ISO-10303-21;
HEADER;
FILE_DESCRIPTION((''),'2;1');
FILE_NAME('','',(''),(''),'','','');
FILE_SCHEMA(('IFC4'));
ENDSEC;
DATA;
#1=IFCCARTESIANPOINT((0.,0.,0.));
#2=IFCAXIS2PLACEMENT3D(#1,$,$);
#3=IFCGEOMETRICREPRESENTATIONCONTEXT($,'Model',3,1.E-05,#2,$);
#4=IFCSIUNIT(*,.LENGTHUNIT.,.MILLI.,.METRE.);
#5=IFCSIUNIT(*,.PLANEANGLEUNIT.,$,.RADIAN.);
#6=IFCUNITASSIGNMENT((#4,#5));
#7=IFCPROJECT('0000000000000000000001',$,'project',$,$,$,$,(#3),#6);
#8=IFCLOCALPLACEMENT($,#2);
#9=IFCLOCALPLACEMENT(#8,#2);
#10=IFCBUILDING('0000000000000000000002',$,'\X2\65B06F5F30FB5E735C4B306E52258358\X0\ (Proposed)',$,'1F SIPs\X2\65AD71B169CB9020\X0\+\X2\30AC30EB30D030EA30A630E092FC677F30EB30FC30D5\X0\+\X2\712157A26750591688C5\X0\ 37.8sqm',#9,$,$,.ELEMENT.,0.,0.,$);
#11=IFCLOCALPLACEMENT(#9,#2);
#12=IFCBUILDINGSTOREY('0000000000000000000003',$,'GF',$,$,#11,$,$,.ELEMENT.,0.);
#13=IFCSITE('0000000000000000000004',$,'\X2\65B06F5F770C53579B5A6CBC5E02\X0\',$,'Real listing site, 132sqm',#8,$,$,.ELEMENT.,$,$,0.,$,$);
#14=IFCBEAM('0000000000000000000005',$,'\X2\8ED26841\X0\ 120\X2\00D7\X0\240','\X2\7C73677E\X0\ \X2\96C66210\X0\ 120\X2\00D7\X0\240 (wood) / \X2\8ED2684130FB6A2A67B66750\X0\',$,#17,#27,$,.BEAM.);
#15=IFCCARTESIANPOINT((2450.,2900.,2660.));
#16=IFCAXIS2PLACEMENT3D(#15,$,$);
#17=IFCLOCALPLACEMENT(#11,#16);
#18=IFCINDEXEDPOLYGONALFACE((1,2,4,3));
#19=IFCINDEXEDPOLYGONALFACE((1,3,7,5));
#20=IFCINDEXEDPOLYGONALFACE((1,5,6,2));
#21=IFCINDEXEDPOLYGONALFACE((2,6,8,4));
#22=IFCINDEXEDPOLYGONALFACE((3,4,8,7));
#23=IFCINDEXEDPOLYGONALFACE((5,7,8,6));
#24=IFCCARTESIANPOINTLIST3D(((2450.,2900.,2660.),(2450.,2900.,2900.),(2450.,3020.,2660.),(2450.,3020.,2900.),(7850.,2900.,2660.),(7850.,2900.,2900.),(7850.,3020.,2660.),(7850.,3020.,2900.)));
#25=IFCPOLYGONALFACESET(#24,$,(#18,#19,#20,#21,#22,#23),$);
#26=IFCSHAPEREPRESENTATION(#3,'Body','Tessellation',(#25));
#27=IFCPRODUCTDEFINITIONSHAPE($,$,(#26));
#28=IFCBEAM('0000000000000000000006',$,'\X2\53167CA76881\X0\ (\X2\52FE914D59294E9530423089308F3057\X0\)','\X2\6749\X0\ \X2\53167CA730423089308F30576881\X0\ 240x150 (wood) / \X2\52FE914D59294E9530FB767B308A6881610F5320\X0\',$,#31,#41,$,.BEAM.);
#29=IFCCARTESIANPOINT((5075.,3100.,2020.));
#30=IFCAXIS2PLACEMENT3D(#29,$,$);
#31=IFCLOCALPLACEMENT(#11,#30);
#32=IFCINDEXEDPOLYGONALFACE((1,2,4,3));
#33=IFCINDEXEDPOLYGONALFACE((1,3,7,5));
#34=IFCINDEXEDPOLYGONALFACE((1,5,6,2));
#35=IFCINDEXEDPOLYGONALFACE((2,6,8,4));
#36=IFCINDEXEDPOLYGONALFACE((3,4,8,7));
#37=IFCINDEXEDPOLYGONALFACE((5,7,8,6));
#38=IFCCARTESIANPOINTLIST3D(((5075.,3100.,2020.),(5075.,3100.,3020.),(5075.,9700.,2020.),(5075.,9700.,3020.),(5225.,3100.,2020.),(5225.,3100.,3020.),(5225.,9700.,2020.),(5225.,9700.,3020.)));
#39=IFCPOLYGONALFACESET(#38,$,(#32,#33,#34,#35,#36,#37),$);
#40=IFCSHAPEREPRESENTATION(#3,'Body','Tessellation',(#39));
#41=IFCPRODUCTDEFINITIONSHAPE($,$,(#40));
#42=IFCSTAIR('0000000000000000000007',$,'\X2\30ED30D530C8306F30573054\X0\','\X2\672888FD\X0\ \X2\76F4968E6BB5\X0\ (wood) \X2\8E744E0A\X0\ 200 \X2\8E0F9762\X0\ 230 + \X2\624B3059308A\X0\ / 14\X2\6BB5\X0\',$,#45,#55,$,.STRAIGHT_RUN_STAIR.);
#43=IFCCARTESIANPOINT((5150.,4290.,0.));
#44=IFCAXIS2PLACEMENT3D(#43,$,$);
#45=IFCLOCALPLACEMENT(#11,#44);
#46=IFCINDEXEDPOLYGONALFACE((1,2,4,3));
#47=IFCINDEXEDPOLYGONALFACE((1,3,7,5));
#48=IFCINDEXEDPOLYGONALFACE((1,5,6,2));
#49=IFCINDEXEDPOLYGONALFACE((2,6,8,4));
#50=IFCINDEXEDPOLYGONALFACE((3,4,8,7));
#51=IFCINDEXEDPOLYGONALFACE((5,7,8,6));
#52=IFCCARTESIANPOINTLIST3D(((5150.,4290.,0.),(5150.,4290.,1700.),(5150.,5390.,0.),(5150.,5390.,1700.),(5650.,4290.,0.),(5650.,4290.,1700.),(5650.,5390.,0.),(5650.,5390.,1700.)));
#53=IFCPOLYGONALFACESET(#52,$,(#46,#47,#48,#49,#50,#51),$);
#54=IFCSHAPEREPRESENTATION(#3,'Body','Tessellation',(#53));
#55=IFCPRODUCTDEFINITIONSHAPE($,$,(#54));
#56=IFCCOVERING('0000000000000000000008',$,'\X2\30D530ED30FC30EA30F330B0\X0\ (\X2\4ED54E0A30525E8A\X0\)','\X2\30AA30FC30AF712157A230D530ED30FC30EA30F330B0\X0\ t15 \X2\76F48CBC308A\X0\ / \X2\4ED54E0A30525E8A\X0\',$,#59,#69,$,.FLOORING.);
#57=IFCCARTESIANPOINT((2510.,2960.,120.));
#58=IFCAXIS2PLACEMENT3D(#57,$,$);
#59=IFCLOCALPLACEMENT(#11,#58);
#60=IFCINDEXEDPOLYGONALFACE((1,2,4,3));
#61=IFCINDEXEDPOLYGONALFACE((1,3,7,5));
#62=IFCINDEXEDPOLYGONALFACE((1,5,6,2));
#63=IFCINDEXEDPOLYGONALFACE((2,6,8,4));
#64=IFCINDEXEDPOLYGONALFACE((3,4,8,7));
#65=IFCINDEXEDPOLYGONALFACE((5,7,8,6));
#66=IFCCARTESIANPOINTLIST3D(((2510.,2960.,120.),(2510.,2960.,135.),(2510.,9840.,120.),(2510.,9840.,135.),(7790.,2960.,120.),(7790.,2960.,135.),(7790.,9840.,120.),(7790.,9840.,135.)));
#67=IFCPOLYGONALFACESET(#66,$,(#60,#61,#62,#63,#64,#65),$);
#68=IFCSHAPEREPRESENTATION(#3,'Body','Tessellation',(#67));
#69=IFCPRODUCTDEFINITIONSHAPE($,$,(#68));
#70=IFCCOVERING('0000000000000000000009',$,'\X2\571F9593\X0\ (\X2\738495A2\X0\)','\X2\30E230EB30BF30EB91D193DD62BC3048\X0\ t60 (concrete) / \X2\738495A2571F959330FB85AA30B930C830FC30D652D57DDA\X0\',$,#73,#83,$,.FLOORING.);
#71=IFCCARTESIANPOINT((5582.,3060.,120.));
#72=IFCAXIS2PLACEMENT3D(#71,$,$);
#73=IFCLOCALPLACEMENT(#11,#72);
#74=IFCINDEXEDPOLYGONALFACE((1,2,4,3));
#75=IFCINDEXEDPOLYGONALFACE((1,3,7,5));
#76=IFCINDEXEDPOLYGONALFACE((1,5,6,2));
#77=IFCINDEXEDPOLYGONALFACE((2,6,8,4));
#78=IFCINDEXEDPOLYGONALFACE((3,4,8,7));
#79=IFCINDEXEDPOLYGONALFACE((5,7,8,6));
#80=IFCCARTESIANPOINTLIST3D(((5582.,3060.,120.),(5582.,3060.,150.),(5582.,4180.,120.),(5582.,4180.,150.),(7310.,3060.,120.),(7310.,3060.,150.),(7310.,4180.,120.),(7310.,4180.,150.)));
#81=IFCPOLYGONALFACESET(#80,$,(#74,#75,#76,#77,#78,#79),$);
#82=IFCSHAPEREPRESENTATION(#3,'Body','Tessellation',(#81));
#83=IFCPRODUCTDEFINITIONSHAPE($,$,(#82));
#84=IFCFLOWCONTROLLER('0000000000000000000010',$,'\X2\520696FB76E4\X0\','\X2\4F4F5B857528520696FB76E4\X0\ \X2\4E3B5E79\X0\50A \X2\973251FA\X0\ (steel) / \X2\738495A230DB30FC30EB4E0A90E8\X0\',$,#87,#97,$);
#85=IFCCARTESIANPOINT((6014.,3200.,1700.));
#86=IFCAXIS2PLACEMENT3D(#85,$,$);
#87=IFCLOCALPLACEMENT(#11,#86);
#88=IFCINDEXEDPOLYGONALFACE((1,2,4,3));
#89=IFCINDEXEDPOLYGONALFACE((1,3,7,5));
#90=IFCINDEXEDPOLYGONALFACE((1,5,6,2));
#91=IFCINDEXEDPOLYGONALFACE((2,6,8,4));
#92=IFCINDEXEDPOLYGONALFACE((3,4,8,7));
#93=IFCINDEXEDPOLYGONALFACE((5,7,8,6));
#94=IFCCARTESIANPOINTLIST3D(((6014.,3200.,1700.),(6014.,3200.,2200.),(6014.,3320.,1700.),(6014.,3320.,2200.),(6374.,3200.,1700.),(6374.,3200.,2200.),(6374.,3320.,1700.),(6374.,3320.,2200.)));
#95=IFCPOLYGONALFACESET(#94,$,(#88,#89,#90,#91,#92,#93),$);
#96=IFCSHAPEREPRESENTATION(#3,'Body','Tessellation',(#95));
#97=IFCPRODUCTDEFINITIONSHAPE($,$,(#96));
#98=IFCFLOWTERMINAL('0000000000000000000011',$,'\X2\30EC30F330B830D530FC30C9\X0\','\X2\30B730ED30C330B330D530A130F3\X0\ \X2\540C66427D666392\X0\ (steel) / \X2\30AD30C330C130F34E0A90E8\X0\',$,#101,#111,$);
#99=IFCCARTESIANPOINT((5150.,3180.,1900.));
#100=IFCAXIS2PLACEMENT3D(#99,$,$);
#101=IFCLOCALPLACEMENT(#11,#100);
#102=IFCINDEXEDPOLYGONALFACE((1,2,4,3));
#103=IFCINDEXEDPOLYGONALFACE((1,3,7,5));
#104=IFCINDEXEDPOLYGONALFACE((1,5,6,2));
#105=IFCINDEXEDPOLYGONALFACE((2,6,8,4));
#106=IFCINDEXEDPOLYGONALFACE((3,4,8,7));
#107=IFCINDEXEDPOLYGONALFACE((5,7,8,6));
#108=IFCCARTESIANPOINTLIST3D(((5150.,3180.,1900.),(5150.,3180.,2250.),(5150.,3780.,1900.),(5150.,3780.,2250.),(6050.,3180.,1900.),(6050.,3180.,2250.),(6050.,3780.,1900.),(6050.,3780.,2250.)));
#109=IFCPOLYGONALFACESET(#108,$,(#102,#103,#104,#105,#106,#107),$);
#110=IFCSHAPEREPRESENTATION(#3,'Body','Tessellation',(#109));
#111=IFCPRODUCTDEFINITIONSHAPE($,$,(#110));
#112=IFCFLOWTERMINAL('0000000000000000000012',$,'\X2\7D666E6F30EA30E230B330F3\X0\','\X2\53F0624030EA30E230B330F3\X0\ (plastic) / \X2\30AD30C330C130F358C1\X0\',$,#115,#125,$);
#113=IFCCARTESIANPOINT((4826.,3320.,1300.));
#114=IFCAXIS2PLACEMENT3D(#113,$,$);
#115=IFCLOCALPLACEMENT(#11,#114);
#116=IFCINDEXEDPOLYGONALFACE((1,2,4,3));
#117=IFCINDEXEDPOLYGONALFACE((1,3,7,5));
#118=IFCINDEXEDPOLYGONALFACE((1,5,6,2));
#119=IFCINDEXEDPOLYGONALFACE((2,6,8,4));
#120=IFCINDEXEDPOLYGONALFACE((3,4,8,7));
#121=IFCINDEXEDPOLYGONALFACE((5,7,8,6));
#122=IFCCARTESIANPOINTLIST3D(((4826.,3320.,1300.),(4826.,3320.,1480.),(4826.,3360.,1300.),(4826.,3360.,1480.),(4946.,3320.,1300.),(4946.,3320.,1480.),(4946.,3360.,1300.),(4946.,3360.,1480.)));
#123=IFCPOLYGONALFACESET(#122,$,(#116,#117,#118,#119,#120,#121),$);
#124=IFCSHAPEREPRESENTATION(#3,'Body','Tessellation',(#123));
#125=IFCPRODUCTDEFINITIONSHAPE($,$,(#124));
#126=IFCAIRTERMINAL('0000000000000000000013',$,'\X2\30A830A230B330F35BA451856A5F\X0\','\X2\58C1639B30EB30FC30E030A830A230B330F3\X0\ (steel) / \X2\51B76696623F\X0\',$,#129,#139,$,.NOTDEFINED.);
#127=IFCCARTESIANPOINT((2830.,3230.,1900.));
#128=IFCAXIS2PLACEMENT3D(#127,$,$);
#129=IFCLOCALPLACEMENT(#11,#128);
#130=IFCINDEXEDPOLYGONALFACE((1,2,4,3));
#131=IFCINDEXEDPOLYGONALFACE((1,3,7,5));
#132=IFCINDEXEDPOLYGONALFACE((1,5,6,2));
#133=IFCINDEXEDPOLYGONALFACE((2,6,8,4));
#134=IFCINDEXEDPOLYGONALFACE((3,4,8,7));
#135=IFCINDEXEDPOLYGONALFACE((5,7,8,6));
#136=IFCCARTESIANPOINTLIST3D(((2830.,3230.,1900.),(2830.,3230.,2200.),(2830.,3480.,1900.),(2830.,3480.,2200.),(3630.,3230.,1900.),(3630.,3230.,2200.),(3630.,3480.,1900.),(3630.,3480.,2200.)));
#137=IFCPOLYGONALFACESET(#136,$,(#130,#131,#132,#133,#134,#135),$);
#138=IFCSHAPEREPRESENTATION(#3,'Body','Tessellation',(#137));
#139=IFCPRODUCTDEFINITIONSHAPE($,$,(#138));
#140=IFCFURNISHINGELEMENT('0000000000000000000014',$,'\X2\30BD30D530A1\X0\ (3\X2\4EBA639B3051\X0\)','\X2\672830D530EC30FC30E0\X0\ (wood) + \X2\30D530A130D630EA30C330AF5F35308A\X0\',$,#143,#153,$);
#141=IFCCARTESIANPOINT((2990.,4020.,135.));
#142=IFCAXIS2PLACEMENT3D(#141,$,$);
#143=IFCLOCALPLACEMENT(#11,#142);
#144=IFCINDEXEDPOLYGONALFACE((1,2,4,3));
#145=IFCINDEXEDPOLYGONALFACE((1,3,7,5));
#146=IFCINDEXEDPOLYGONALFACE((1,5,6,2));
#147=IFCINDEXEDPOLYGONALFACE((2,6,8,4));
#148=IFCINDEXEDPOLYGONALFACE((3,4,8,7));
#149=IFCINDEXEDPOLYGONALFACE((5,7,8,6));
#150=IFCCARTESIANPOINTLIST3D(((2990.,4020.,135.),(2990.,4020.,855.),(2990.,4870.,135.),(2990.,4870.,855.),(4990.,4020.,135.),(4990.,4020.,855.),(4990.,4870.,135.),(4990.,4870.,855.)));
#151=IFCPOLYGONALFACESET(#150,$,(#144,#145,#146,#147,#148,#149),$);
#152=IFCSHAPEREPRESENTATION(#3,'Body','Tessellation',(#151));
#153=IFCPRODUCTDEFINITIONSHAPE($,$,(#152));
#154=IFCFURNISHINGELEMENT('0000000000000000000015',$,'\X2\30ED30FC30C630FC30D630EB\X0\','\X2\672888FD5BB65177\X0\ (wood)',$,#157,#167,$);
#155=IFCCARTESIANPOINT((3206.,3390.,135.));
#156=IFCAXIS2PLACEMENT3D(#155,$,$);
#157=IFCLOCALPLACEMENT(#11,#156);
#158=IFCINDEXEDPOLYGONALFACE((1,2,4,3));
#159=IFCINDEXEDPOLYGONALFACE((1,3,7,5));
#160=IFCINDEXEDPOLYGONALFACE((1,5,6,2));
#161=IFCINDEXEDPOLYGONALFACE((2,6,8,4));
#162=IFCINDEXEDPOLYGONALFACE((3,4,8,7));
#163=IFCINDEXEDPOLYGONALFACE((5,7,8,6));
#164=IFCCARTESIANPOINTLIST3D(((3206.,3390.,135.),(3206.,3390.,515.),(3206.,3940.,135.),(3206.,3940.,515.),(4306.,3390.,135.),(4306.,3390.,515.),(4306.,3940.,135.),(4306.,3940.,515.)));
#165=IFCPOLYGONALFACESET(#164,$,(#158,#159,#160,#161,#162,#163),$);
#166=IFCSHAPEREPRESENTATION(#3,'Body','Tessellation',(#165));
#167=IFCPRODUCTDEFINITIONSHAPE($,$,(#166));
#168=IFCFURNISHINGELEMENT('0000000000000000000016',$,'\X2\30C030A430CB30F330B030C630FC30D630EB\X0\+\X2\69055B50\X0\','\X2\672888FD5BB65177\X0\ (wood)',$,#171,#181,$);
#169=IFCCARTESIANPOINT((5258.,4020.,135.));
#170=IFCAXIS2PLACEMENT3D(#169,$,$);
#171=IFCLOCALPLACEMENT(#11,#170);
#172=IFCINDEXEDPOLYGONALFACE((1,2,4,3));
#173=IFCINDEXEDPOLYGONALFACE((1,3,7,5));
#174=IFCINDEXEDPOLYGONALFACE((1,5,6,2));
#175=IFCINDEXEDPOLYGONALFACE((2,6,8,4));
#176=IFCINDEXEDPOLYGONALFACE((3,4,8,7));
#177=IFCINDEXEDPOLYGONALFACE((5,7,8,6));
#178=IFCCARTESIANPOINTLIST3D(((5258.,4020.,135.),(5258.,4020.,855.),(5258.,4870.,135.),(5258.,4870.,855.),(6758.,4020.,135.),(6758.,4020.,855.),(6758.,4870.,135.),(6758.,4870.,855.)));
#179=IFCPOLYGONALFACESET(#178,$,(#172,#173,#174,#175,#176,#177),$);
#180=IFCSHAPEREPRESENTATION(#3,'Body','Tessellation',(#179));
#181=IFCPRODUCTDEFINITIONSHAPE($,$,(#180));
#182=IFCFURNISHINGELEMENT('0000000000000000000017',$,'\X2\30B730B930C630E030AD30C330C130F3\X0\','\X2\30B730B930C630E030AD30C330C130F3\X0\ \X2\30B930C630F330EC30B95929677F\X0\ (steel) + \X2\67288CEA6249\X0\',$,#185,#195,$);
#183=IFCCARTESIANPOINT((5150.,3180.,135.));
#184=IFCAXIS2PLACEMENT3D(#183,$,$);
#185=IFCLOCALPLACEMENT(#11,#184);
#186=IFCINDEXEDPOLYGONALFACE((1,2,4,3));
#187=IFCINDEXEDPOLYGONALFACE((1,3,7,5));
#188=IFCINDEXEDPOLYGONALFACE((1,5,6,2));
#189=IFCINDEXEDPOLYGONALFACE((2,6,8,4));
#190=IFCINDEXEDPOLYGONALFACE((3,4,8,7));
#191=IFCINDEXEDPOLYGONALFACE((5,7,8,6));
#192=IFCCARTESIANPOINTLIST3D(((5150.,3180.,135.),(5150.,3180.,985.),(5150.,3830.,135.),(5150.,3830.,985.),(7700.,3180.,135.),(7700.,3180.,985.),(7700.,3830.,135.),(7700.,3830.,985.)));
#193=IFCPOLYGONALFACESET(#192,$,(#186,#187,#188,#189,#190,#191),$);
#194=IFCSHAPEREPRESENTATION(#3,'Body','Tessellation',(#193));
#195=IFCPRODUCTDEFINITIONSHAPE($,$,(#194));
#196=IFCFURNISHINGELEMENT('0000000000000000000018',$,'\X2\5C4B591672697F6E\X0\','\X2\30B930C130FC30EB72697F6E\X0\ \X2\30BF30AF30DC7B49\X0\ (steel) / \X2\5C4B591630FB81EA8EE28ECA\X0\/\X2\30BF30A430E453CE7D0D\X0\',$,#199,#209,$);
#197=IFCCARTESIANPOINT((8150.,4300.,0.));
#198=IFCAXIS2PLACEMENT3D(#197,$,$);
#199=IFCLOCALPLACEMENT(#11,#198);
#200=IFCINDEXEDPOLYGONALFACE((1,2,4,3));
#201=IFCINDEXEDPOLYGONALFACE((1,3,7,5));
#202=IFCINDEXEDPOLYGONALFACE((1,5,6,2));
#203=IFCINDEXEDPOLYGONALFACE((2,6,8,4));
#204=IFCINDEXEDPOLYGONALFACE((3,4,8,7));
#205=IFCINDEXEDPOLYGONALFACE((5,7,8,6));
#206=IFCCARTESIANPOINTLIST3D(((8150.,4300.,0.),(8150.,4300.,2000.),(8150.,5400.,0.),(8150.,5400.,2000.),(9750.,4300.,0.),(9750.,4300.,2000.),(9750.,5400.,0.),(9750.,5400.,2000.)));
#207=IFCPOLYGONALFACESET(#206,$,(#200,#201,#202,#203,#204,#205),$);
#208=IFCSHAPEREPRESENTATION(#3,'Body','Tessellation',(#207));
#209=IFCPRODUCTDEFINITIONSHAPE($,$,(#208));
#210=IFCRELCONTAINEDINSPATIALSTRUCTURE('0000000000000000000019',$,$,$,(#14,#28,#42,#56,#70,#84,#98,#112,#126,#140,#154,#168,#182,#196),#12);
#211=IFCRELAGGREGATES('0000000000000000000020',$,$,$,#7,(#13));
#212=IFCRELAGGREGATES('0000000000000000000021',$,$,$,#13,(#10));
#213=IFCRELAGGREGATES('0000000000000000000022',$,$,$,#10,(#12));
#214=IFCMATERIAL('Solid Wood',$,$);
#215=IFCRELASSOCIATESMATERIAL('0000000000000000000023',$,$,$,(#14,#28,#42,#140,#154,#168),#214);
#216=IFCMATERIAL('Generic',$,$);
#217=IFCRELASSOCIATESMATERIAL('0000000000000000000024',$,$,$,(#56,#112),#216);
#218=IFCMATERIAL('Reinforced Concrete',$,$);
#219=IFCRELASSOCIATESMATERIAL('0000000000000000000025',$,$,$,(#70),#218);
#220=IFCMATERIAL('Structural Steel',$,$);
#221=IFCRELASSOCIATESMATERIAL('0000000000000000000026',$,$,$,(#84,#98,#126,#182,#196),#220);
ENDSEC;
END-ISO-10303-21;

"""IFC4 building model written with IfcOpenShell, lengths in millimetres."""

from ifc_helpers import new_model, si_unit, frame, frame_2d, origin, place, context, project, spatial, rectangle, extrude, material, element, save


model = new_model("IFC4")

# Units and contexts
model_context = context("Model", 3, precision=1e-05, world=origin())
ifc_project = project(units=[si_unit("LENGTHUNIT", "METRE", prefix="MILLI"), si_unit("PLANEANGLEUNIT", "RADIAN")], contexts=[model_context])

# Site, building, storey
site_placement = place(None, origin())
site = spatial("IfcSite", under=ifc_project, at=site_placement, Name="新潟県南魚沼市", ObjectType="Real listing site, 132sqm", CompositionType="ELEMENT", RefElevation=0.0)
building_placement = place(site_placement, origin())
building = spatial("IfcBuilding", under=site, at=building_placement, Name="新潟・平屋の別荘 (Proposed)", ObjectType="1F SIPs断熱構造+ガルバリウム鋼板ルーフ+無垢材外装 37.8sqm", CompositionType="ELEMENT", ElevationOfRefHeight=0.0, ElevationOfTerrain=0.0)
storey_placement = place(building_placement, origin())
storey = spatial("IfcBuildingStorey", under=building, at=storey_placement, Name="GF", CompositionType="ELEMENT", Elevation=0.0)

# Beams
ifc_material_1 = material(Name="Solid Wood")
beam_1_placement = place(storey_placement, frame((2450.0, 2900.0, 2660.0)))
element("IfcBeam", 1, at=beam_1_placement, inside=storey, material=ifc_material_1, Name="軒桁 120×240", Description="米松 集成 120×240 (wood) / 軒桁・横架材", PredefinedType="BEAM", context=model_context, shape_type="SweptSolid", body=[
    extrude(rectangle(XDim=5400.0, YDim=120.0, at=frame_2d((2700.0, 60.0))), frame((2450.0, 2900.0, 2660.0)), (0.0, 0.0, 1.0), 240.0),
])
beam_2_placement = place(storey_placement, frame((5075.0, 3100.0, 2020.0)))
element("IfcBeam", 2, at=beam_2_placement, inside=storey, material=ifc_material_1, Name="化粧梁 (勾配天井あらわし)", Description="杉 化粧あらわし梁 240x150 (wood) / 勾配天井・登り梁意匠", PredefinedType="BEAM", context=model_context, shape_type="SweptSolid", body=[
    extrude(rectangle(XDim=150.0, YDim=6600.0, at=frame_2d((75.0, 3300.0))), frame((5075.0, 3100.0, 2020.0)), (0.0, 0.0, 1.0), 1000.0),
])

# Stair
stair_placement = place(storey_placement, frame((5150.0, 4290.0, 0.0)))
element("IfcStair", 3, at=stair_placement, inside=storey, material=ifc_material_1, Name="ロフトはしご", Description="木製 直階段 (wood) 蹴上 200 踏面 230 + 手すり / 14段", PredefinedType="STRAIGHT_RUN_STAIR", context=model_context, shape_type="SweptSolid", body=[
    extrude(rectangle(XDim=500.0, YDim=1100.0, at=frame_2d((250.0, 550.0))), frame((5150.0, 4290.0, 0.0)), (0.0, 0.0, 1.0), 1700.0),
])

# Coverings
ifc_material_2 = material(Name="Generic")
covering_1_placement = place(storey_placement, frame((2510.0, 2960.0, 120.0)))
element("IfcCovering", 4, at=covering_1_placement, inside=storey, material=ifc_material_2, Name="フローリング (仕上げ床)", Description="オーク無垢フローリング t15 直貼り / 仕上げ床", PredefinedType="FLOORING", context=model_context, shape_type="SweptSolid", body=[
    extrude(rectangle(XDim=5280.0, YDim=6880.0, at=frame_2d((2640.0, 3440.0))), frame((2510.0, 2960.0, 120.0)), (0.0, 0.0, 1.0), 15.0),
])
ifc_material_3 = material(Name="Reinforced Concrete")
covering_2_placement = place(storey_placement, frame((5582.0, 3060.0, 120.0)))
element("IfcCovering", 5, at=covering_2_placement, inside=storey, material=ifc_material_3, Name="土間 (玄関)", Description="モルタル金鏝押え t60 (concrete) / 玄関土間・薪ストーブ動線", PredefinedType="FLOORING", context=model_context, shape_type="SweptSolid", body=[
    extrude(rectangle(XDim=1728.0, YDim=1120.0, at=frame_2d((864.0, 560.0))), frame((5582.0, 3060.0, 120.0)), (0.0, 0.0, 1.0), 30.0),
])

# Flow controller
ifc_material_4 = material(Name="Structural Steel")
flow_controller_placement = place(storey_placement, frame((6014.0, 3200.0, 1700.0)))
element("IfcFlowController", 6, at=flow_controller_placement, inside=storey, material=ifc_material_4, Name="分電盤", Description="住宅用分電盤 主幹50A 露出 (steel) / 玄関ホール上部", context=model_context, shape_type="SweptSolid", body=[
    extrude(rectangle(XDim=360.0, YDim=120.0, at=frame_2d((180.0, 60.0))), frame((6014.0, 3200.0, 1700.0)), (0.0, 0.0, 1.0), 500.0),
])

# Flow terminals
flow_terminal_1_placement = place(storey_placement, frame((5150.0, 3180.0, 1900.0)))
element("IfcFlowTerminal", 7, at=flow_terminal_1_placement, inside=storey, material=ifc_material_4, Name="レンジフード", Description="シロッコファン 同時給排 (steel) / キッチン上部", context=model_context, shape_type="SweptSolid", body=[
    extrude(rectangle(XDim=900.0, YDim=600.0, at=frame_2d((450.0, 300.0))), frame((5150.0, 3180.0, 1900.0)), (0.0, 0.0, 1.0), 350.0),
])
flow_terminal_2_placement = place(storey_placement, frame((4826.0, 3320.0, 1300.0)))
element("IfcFlowTerminal", 8, at=flow_terminal_2_placement, inside=storey, material=ifc_material_2, Name="給湯リモコン", Description="台所リモコン (plastic) / キッチン壁", context=model_context, shape_type="SweptSolid", body=[
    extrude(rectangle(XDim=120.0, YDim=40.0, at=frame_2d((60.0, 20.0))), frame((4826.0, 3320.0, 1300.0)), (0.0, 0.0, 1.0), 180.0),
])

# Air terminal
air_terminal_placement = place(storey_placement, frame((2830.0, 3230.0, 1900.0)))
element("IfcAirTerminal", 9, at=air_terminal_placement, inside=storey, material=ifc_material_4, Name="エアコン室内機", Description="壁掛ルームエアコン (steel) / 冷暖房", PredefinedType="NOTDEFINED", context=model_context, shape_type="SweptSolid", body=[
    extrude(rectangle(XDim=800.0, YDim=250.0, at=frame_2d((400.0, 125.0))), frame((2830.0, 3230.0, 1900.0)), (0.0, 0.0, 1.0), 300.0),
])

# Furnishing elements
furnishing_1_placement = place(storey_placement, frame((2990.0, 4020.0, 135.0)))
element("IfcFurnishingElement", 10, at=furnishing_1_placement, inside=storey, material=ifc_material_1, Name="ソファ (3人掛け)", Description="木フレーム (wood) + ファブリック張り", context=model_context, shape_type="SweptSolid", body=[
    extrude(rectangle(XDim=2000.0, YDim=850.0, at=frame_2d((1000.0, 425.0))), frame((2990.0, 4020.0, 135.0)), (0.0, 0.0, 1.0), 720.0),
])
furnishing_2_placement = place(storey_placement, frame((3206.0, 3390.0, 135.0)))
element("IfcFurnishingElement", 11, at=furnishing_2_placement, inside=storey, material=ifc_material_1, Name="ローテーブル", Description="木製家具 (wood)", context=model_context, shape_type="SweptSolid", body=[
    extrude(rectangle(XDim=1100.0, YDim=550.0, at=frame_2d((550.0, 275.0))), frame((3206.0, 3390.0, 135.0)), (0.0, 0.0, 1.0), 380.0),
])
furnishing_3_placement = place(storey_placement, frame((5258.0, 4020.0, 135.0)))
element("IfcFurnishingElement", 12, at=furnishing_3_placement, inside=storey, material=ifc_material_1, Name="ダイニングテーブル+椅子", Description="木製家具 (wood)", context=model_context, shape_type="SweptSolid", body=[
    extrude(rectangle(XDim=1500.0, YDim=850.0, at=frame_2d((750.0, 425.0))), frame((5258.0, 4020.0, 135.0)), (0.0, 0.0, 1.0), 720.0),
])
furnishing_4_placement = place(storey_placement, frame((5150.0, 3180.0, 135.0)))
element("IfcFurnishingElement", 13, at=furnishing_4_placement, inside=storey, material=ifc_material_4, Name="システムキッチン", Description="システムキッチン ステンレス天板 (steel) + 木質扉", context=model_context, shape_type="SweptSolid", body=[
    extrude(rectangle(XDim=2550.0, YDim=650.0, at=frame_2d((1275.0, 325.0))), frame((5150.0, 3180.0, 135.0)), (0.0, 0.0, 1.0), 850.0),
])
furnishing_5_placement = place(storey_placement, frame((8150.0, 4300.0, 0.0)))
element("IfcFurnishingElement", 14, at=furnishing_5_placement, inside=storey, material=ifc_material_4, Name="屋外物置", Description="スチール物置 タクボ等 (steel) / 屋外・自転車/タイヤ収納", context=model_context, shape_type="SweptSolid", body=[
    extrude(rectangle(XDim=1600.0, YDim=1100.0, at=frame_2d((800.0, 550.0))), frame((8150.0, 4300.0, 0.0)), (0.0, 0.0, 1.0), 2000.0),
])

save(model, "model.ifc")
